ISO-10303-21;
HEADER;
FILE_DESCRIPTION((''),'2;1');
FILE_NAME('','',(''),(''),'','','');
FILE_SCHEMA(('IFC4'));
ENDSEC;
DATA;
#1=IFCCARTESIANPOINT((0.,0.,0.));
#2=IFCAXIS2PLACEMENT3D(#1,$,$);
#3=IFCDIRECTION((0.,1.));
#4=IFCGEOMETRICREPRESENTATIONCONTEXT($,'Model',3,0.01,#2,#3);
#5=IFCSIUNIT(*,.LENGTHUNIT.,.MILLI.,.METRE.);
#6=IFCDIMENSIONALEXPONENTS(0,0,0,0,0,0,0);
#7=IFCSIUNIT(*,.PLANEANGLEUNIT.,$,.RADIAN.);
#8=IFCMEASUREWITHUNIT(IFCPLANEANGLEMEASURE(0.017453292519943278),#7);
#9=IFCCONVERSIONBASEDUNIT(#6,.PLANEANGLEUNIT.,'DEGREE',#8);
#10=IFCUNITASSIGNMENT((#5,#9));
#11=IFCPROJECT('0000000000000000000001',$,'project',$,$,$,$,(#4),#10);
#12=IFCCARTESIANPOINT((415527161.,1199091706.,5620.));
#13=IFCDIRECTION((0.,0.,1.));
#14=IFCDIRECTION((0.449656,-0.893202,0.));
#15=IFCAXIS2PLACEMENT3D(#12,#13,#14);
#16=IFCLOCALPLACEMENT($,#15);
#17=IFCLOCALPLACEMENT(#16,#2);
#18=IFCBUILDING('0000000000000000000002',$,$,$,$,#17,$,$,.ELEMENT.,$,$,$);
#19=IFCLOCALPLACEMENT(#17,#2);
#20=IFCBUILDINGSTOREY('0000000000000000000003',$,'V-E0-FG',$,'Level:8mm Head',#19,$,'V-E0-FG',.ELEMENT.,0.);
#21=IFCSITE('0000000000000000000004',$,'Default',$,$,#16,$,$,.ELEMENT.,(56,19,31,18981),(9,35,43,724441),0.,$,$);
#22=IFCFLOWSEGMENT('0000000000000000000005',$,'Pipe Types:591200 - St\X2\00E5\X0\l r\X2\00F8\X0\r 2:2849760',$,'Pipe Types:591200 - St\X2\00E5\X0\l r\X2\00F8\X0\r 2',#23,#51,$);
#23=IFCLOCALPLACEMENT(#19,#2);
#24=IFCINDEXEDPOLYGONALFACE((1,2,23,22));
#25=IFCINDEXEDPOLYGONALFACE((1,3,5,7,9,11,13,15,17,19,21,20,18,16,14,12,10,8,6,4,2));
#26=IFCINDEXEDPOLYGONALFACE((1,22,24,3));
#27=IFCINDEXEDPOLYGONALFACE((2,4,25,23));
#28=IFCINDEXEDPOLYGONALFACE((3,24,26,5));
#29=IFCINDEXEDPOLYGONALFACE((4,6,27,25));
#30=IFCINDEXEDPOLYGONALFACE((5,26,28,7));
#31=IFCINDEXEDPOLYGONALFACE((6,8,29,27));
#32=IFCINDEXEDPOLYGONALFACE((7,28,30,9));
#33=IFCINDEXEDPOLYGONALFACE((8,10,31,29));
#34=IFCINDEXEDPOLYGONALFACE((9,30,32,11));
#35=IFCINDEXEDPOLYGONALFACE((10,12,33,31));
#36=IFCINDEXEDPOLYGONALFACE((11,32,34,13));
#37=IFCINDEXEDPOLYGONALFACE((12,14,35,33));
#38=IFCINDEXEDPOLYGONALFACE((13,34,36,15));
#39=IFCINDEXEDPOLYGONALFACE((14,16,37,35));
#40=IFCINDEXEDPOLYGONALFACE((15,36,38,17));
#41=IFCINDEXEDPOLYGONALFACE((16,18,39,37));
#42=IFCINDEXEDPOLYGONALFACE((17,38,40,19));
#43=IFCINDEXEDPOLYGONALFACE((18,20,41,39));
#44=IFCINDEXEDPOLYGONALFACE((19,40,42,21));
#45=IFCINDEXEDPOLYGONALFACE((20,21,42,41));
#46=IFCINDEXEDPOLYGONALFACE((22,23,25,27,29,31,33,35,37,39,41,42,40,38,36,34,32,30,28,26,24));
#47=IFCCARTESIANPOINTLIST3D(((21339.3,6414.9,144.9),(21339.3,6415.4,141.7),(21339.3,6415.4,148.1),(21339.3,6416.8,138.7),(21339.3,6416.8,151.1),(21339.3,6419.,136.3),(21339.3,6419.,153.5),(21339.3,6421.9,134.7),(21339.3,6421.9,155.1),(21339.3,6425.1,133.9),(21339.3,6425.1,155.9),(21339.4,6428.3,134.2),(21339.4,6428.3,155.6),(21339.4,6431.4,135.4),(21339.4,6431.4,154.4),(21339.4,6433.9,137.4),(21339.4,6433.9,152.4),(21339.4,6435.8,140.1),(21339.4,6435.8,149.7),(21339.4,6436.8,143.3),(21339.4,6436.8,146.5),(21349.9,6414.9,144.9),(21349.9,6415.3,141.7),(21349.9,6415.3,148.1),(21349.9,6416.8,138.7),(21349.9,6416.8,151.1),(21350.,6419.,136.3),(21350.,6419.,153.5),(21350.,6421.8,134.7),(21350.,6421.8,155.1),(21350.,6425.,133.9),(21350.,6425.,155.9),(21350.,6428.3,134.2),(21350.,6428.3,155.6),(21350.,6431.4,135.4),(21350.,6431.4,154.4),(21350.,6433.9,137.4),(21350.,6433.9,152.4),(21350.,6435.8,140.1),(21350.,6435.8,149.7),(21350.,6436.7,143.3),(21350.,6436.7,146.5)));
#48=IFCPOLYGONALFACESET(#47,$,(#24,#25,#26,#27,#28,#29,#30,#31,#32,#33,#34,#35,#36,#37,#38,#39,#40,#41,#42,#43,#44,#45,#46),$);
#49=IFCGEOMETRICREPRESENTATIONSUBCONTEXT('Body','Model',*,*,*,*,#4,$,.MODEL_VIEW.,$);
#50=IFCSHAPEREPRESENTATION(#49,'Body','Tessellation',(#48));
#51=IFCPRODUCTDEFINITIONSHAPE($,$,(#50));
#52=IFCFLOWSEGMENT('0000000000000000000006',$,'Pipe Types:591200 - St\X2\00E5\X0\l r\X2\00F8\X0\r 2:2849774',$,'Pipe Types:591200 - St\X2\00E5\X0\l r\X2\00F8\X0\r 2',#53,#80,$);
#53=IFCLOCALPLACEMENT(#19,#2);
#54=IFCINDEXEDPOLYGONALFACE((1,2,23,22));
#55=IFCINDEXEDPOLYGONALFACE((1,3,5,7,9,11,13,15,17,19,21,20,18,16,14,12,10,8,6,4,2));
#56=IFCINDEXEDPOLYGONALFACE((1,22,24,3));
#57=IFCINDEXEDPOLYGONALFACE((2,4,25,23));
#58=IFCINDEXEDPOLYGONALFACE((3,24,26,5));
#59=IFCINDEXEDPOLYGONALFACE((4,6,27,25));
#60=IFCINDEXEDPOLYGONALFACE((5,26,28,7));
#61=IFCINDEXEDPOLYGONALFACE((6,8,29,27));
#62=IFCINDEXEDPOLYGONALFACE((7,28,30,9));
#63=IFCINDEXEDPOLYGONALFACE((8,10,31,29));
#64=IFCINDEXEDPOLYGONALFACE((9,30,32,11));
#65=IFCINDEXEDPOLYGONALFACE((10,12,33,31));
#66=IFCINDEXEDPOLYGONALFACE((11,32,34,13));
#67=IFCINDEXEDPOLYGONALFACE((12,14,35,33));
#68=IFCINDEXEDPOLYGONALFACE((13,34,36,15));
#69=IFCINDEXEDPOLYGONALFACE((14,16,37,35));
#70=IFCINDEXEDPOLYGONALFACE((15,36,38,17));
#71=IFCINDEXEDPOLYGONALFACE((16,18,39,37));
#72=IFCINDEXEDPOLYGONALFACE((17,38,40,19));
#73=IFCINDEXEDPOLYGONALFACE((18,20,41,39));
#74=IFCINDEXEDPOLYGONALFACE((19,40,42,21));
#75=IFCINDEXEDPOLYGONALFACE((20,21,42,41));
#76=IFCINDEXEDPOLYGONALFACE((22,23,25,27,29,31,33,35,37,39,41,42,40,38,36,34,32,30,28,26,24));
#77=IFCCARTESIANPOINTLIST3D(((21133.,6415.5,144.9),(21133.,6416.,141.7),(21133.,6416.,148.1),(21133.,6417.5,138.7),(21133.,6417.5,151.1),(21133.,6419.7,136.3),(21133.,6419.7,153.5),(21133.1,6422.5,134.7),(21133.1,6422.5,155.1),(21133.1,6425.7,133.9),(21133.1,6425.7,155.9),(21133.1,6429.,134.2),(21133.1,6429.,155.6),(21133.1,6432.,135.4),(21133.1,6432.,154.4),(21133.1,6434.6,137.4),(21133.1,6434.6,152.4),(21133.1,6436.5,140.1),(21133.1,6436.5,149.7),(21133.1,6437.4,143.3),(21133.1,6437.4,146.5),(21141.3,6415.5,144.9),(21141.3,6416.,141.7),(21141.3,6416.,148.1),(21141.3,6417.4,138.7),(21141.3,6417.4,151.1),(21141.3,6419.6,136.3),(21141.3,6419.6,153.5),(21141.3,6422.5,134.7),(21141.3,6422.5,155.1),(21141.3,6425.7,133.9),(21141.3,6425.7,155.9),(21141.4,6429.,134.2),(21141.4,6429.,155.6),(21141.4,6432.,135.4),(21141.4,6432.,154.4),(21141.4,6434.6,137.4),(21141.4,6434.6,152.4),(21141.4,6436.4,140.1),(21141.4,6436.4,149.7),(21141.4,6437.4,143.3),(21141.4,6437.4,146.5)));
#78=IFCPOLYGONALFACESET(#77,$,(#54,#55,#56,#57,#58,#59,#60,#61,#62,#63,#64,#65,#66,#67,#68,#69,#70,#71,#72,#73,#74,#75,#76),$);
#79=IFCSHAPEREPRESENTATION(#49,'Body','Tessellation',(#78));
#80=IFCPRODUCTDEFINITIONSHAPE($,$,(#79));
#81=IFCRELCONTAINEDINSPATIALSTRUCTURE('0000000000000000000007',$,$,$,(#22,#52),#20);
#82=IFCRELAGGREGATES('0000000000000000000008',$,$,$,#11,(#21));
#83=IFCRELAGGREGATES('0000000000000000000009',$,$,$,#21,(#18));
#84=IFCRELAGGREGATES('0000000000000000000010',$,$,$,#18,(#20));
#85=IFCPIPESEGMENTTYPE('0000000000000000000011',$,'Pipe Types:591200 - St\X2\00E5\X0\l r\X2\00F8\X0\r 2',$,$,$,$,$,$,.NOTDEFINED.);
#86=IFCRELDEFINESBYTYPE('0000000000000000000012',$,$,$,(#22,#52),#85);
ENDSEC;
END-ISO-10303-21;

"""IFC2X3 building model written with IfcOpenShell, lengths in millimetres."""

from ifc_helpers import new_model, entity, si_unit, converted_unit, direction, frame, frame_2d, origin, origin_2d_with_axis, place, context, subcontext, project, spatial, circle, extrude, type_object, element, save


model = new_model("IFC2X3")

# Units and contexts
model_context = context("Model", 3, precision=0.01, world=origin(), true_north=direction((0.0, 1.0)))
body_context = subcontext(model_context, "Body", "Model", "MODEL_VIEW")
ifc_project = project(units=[si_unit("LENGTHUNIT", "METRE", prefix="MILLI"), converted_unit("PLANEANGLEUNIT", "DEGREE", entity("IfcPlaneAngleMeasure", 0.017453292519943278), si_unit("PLANEANGLEUNIT", "RADIAN"), dimensions=[0, 0, 0, 0, 0, 0, 0])], contexts=[model_context])

# Site, building, storey
site_placement = place(None, frame((415527161.0, 1199091706.0, 5620.0), z_axis=(0.0, 0.0, 1.0), x_axis=(0.449656, -0.893202, 0.0)))
site = spatial("IfcSite", under=ifc_project, at=site_placement, Name="Default", CompositionType="ELEMENT", RefLatitude=(56, 19, 31, 18981), RefLongitude=(9, 35, 43, 724441), RefElevation=0.0)
building_placement = place(site_placement, origin())
building = spatial("IfcBuilding", under=site, at=building_placement, CompositionType="ELEMENT")
storey_placement = place(building_placement, origin())
storey = spatial("IfcBuildingStorey", under=building, at=storey_placement, Name="V-E0-FG", ObjectType="Level:8mm Head", LongName="V-E0-FG", CompositionType="ELEMENT", Elevation=0.0)

# Flow segments
pipe_segment_type_1 = type_object("IfcPipeSegmentType", Name="Pipe Types:591200 - Stål rør 2", PredefinedType="NOTDEFINED")
flow_segment_1_placement = place(storey_placement, origin())
element("IfcFlowSegment", 1, at=flow_segment_1_placement, inside=storey, type_object=pipe_segment_type_1, Name="Pipe Types:591200 - Stål rør 2:2849760", ObjectType="Pipe Types:591200 - Stål rør 2", context=body_context, shape_type="SweptSolid", body=[
    extrude(circle(Radius=11.0, at=frame_2d((0.0, 0.0), x_axis=(1.0, 0.0))), frame((21339.3, 6425.9, 144.9), z_axis=(0.999996, -0.002778, 0.0), x_axis=(-0.002778, -0.999996, 0.0)), (0.0, 0.0, 1.0), 10.6),
])
flow_segment_2_placement = place(storey_placement, origin())
element("IfcFlowSegment", 2, at=flow_segment_2_placement, inside=storey, type_object=pipe_segment_type_1, Name="Pipe Types:591200 - Stål rør 2:2849774", ObjectType="Pipe Types:591200 - Stål rør 2", context=body_context, shape_type="SweptSolid", body=[
    extrude(circle(Radius=11.0, at=origin_2d_with_axis()), frame((21133.1, 6426.5, 144.9), z_axis=(0.99999, -0.004456, 0.0), x_axis=(-0.004456, -0.99999, 0.0)), (0.0, 0.0, 1.0), 8.3),
])

save(model, "model.ifc")
